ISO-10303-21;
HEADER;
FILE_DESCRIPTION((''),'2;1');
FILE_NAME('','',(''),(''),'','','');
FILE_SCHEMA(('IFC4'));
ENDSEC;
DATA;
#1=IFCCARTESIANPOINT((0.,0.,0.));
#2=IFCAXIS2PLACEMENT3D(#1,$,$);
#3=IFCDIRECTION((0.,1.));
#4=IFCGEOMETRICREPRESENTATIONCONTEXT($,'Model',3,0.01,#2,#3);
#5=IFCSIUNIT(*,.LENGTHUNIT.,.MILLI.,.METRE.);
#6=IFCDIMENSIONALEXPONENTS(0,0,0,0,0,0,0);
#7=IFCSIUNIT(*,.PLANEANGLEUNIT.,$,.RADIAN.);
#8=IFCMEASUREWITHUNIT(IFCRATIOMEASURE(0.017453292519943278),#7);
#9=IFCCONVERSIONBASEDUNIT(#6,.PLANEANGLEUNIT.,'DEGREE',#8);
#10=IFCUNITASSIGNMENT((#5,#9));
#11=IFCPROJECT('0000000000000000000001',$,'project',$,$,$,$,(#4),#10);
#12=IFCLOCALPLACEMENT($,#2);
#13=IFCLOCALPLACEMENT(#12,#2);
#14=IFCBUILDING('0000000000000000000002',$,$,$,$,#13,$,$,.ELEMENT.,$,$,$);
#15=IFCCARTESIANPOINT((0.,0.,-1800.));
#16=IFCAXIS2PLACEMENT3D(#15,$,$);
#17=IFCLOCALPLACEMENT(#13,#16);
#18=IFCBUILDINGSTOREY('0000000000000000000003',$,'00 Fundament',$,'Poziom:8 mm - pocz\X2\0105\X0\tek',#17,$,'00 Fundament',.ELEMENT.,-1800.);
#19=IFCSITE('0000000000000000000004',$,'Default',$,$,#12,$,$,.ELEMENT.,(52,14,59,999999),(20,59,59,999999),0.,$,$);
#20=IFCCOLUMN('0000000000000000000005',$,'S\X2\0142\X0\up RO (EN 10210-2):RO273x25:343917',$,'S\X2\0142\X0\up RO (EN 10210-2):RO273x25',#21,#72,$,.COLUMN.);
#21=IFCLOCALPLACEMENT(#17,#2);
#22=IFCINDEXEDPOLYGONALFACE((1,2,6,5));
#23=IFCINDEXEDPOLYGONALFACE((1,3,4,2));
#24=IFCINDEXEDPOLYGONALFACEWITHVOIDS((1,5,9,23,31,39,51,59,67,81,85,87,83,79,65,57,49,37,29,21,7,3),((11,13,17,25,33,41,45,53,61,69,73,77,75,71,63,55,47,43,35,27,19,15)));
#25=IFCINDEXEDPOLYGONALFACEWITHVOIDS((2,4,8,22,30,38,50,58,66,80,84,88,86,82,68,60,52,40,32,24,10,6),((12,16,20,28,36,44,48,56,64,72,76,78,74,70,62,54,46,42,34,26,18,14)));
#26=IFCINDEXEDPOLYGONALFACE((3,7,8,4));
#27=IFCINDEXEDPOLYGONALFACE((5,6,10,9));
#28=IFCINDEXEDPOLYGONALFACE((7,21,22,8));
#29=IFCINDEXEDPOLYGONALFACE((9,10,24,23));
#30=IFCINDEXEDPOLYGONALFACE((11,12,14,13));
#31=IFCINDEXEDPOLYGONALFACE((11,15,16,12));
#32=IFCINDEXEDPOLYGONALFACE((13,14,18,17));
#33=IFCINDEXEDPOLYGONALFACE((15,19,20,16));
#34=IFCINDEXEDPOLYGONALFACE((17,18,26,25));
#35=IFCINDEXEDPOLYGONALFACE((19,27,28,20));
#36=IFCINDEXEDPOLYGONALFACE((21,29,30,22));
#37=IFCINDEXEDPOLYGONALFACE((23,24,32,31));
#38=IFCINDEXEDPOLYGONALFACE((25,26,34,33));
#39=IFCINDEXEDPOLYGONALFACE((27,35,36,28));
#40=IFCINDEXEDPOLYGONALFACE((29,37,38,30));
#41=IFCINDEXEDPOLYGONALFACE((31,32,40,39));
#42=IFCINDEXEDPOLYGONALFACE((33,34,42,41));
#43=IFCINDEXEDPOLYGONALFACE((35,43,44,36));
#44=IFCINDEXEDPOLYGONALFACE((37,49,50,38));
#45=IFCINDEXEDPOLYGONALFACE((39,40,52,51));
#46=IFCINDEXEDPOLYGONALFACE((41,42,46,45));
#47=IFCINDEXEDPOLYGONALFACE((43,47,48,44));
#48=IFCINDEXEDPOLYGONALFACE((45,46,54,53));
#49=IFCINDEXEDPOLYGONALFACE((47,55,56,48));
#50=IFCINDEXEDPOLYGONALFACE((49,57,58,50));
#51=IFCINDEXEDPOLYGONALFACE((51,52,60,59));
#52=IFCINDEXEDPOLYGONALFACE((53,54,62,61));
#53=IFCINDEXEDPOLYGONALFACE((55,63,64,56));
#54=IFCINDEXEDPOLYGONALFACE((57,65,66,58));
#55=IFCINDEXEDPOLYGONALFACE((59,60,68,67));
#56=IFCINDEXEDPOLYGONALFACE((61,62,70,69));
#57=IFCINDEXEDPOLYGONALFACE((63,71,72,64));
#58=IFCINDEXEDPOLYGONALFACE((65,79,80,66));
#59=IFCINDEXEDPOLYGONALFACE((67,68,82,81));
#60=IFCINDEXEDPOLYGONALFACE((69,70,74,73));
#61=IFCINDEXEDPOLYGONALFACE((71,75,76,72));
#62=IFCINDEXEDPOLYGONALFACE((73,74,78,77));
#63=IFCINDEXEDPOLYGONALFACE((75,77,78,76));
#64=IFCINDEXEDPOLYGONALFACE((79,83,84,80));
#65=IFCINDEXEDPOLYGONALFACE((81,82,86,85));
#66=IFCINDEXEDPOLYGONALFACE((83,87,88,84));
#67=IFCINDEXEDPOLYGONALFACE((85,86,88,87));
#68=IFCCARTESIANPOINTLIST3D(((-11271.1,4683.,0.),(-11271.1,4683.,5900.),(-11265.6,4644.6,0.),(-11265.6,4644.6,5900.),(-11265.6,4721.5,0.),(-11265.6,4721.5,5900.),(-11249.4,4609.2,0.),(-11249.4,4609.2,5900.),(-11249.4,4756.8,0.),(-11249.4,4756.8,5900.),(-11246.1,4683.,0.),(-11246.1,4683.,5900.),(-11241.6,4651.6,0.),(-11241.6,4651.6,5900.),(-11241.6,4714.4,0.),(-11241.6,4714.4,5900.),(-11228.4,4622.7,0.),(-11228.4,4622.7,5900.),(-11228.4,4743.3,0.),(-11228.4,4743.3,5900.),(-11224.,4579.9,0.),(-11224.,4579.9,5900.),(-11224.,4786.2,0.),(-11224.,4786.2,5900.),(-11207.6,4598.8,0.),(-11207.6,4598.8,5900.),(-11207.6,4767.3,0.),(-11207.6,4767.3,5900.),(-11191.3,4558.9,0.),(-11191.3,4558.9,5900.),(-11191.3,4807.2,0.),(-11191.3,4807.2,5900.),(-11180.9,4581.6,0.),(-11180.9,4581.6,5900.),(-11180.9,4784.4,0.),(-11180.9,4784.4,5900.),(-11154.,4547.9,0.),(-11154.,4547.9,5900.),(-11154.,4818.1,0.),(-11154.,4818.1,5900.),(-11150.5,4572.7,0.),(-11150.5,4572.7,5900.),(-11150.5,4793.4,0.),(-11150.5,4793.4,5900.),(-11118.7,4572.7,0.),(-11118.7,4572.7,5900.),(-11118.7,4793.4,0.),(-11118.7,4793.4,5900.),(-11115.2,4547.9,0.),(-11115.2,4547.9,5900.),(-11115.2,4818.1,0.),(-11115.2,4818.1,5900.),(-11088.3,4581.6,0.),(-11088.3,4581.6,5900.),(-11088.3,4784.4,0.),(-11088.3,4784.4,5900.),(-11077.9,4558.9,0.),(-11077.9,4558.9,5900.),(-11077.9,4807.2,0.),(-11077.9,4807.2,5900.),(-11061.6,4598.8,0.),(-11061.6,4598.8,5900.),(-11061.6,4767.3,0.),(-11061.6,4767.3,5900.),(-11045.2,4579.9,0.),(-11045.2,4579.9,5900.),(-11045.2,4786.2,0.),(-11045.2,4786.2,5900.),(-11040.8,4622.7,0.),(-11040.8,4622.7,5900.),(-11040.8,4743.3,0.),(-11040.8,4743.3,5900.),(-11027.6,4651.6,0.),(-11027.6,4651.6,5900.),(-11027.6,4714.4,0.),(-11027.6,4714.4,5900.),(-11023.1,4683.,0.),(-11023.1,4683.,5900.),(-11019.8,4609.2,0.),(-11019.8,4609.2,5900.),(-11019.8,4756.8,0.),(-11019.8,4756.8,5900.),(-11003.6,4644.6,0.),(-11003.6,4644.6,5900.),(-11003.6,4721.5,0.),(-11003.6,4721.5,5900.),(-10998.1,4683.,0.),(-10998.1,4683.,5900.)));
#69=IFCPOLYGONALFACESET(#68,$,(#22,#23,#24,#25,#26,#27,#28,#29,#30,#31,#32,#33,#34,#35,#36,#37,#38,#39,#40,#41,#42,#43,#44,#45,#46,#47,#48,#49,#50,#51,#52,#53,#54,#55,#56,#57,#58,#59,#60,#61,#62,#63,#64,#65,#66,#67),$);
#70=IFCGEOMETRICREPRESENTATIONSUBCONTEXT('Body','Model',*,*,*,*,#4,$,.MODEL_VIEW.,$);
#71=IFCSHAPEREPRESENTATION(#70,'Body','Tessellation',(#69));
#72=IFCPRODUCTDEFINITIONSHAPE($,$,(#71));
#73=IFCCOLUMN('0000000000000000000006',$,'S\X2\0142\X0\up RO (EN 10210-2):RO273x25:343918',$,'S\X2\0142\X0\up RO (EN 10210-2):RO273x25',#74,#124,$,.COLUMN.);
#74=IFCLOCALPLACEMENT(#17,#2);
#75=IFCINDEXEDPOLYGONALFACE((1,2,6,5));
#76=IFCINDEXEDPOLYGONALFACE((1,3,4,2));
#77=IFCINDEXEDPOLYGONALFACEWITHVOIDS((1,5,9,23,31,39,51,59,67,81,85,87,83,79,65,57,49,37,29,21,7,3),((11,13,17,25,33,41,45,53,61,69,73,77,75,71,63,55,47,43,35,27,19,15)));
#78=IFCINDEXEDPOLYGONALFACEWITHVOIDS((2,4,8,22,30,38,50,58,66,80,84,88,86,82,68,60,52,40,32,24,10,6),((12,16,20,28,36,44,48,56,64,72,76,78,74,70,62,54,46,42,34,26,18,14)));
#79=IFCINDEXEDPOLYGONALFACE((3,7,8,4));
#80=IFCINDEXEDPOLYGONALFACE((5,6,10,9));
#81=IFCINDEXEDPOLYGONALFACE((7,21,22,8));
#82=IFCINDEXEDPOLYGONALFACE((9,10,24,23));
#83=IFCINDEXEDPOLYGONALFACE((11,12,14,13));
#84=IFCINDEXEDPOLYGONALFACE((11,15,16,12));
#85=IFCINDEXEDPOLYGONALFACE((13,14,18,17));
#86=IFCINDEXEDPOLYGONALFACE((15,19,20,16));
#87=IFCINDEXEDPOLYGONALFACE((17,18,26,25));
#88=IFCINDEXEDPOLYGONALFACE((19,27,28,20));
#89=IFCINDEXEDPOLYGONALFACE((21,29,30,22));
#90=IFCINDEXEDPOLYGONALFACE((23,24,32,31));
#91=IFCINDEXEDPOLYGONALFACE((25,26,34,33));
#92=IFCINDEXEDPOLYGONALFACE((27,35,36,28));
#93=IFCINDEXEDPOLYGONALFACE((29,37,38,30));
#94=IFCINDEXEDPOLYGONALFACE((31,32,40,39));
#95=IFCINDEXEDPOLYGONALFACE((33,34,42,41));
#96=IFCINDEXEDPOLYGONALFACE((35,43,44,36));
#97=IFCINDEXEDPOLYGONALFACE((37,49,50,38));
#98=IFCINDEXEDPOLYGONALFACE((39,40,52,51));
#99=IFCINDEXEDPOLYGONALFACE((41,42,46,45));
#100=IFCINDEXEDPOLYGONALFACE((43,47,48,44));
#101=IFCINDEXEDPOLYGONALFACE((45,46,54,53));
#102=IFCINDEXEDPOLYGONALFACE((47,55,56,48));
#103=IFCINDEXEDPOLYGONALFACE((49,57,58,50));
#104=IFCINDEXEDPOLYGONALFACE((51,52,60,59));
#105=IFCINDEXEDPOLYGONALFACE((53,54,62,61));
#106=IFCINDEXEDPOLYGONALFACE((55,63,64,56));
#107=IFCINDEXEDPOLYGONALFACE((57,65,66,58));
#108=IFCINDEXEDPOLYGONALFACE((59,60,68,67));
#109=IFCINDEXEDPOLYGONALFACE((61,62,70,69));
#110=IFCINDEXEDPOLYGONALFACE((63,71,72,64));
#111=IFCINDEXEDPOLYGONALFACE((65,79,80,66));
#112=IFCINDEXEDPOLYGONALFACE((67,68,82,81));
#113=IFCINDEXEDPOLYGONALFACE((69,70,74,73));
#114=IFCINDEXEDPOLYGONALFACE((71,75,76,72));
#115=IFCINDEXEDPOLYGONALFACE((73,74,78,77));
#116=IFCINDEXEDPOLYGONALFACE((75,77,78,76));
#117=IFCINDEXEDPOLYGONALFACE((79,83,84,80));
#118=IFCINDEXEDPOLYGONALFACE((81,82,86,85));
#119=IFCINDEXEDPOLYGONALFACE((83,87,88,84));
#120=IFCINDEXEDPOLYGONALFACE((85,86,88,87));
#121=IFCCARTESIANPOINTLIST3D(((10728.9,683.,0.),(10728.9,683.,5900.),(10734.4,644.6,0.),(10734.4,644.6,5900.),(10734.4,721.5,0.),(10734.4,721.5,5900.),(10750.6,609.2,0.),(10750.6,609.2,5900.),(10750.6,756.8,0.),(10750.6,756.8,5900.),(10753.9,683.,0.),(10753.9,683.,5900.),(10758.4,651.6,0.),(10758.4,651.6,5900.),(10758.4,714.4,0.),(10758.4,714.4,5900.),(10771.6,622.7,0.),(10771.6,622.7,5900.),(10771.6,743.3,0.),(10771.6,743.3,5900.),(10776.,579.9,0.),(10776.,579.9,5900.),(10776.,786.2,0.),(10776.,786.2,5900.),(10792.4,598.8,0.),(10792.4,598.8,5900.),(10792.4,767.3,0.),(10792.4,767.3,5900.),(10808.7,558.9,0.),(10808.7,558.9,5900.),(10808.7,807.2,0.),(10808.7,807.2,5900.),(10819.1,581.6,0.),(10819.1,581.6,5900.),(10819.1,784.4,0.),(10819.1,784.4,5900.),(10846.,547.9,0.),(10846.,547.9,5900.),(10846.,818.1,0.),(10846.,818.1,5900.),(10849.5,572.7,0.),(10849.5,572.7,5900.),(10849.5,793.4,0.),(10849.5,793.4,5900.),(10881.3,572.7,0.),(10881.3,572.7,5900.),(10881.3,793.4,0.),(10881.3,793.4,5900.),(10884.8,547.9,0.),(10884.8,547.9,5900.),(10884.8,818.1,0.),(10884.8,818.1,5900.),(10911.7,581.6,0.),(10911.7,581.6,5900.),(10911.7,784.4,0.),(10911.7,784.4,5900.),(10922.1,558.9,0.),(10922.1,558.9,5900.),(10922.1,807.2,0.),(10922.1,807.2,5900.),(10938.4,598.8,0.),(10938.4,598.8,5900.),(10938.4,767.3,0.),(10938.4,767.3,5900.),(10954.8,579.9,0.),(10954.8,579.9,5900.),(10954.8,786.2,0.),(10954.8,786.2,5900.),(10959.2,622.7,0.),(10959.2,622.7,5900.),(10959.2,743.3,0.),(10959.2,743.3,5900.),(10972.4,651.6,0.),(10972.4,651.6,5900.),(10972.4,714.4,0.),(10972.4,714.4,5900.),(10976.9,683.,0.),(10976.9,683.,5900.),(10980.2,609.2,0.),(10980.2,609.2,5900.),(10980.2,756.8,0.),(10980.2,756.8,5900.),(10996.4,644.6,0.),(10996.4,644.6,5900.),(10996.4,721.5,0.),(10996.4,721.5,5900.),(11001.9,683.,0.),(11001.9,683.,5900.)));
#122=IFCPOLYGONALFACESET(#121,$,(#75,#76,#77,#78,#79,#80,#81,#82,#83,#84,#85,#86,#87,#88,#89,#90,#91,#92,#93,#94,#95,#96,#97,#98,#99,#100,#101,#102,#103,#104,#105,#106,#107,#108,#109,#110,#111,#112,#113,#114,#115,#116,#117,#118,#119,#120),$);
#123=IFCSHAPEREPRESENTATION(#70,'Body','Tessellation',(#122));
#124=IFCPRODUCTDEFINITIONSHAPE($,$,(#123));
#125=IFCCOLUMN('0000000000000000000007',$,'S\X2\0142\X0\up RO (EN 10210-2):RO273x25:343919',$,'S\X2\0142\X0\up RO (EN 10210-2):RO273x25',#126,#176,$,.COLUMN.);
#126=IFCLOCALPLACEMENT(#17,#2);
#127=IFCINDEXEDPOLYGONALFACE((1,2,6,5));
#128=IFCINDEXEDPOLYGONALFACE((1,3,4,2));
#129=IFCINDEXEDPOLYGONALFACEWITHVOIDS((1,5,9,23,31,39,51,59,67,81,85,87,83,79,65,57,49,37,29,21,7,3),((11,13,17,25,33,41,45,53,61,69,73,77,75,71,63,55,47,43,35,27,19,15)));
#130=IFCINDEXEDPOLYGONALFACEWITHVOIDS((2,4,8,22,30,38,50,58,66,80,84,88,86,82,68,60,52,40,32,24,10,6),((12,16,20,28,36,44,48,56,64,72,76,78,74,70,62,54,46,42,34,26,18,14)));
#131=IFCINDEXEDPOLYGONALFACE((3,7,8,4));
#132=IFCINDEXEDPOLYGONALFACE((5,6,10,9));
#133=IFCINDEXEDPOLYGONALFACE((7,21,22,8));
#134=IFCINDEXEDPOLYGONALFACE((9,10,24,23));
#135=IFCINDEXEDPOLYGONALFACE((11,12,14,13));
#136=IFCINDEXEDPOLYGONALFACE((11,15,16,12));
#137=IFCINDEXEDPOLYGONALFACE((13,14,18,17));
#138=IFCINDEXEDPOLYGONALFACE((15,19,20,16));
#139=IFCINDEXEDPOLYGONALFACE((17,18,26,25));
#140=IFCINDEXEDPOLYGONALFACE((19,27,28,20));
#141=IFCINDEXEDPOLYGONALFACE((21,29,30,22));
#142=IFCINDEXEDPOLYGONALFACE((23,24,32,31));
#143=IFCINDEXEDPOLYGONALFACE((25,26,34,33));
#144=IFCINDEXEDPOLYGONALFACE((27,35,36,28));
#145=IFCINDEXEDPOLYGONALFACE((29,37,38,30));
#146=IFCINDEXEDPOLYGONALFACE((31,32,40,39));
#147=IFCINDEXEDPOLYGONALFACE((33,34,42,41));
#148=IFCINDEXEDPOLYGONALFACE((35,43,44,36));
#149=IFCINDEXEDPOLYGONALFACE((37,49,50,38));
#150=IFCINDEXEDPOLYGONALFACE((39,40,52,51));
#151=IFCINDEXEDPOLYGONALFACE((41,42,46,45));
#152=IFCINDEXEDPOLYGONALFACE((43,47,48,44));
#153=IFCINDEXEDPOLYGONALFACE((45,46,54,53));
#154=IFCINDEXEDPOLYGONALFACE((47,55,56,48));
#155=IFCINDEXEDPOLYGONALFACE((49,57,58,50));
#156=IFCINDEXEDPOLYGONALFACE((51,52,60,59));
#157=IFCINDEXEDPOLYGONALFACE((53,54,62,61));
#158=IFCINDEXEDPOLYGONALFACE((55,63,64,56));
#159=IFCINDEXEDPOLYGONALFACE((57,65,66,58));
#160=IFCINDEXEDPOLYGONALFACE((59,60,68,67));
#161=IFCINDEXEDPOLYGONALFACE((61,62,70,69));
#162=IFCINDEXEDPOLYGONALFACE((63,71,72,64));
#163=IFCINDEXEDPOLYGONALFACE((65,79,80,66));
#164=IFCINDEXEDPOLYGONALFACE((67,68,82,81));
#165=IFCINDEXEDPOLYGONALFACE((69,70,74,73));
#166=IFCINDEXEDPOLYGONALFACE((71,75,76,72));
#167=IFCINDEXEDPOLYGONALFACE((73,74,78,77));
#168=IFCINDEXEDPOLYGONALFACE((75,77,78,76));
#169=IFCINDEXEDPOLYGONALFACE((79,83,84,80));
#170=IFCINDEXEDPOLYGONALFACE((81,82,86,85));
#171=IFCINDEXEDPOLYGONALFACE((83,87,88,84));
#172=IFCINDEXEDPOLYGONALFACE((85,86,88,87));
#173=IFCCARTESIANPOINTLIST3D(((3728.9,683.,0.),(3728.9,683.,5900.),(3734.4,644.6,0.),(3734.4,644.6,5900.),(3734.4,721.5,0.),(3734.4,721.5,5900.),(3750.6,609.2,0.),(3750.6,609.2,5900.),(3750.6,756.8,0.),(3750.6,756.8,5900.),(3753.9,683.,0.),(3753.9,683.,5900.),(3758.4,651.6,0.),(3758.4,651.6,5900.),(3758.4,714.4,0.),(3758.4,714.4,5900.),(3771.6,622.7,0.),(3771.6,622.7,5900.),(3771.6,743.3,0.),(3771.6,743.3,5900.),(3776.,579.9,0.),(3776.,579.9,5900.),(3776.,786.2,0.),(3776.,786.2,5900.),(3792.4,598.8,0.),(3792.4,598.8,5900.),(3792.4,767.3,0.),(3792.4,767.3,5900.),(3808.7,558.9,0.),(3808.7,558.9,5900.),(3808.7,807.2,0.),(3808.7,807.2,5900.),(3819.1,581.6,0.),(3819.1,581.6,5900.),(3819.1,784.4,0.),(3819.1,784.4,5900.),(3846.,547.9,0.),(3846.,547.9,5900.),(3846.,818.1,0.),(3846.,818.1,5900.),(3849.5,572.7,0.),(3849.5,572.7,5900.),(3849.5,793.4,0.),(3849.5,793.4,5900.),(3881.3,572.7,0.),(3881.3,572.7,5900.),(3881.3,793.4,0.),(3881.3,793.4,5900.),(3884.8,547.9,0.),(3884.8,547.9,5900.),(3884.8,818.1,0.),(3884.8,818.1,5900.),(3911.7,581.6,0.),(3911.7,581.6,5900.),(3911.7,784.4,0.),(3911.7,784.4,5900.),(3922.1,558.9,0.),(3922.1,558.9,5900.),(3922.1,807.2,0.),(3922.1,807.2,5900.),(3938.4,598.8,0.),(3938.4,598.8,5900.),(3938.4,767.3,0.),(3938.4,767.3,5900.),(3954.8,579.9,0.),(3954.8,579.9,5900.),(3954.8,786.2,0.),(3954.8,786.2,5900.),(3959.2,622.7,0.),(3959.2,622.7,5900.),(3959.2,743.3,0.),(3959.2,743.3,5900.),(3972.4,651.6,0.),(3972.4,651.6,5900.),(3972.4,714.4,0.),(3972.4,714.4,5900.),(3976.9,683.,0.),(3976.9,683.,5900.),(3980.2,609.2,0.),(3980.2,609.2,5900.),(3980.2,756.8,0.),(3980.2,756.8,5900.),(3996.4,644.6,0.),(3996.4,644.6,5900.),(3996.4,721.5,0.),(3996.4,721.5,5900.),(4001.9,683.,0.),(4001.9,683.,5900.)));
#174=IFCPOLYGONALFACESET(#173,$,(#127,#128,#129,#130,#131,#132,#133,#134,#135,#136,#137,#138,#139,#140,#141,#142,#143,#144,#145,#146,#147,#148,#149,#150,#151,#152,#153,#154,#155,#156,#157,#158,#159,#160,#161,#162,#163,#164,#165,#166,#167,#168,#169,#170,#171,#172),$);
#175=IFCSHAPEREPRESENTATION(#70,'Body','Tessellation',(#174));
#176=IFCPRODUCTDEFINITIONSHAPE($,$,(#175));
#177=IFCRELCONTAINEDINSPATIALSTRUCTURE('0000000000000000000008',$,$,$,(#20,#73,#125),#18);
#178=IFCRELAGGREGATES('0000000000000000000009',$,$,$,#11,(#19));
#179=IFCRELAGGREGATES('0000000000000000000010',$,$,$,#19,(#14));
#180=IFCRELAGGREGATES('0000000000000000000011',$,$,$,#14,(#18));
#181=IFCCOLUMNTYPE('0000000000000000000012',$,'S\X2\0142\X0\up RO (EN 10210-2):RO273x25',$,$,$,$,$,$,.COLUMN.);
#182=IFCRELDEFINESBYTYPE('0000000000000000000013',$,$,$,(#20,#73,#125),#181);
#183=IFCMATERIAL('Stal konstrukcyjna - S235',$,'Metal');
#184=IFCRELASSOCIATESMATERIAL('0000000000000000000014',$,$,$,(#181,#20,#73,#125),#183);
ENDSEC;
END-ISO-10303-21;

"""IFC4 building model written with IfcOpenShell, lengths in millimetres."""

from ifc_helpers import new_model, entity, si_unit, converted_unit, direction, frame, origin, place, context, subcontext, project, spatial, arc, indexed_curve, outline, extrude, source, transform, mapped, material, type_object, type_shapes, element, save


model = new_model("IFC4")

# Units and contexts
model_context = context("Model", 3, precision=0.01, world=origin(), true_north=direction((0.0, 1.0)))
body_context = subcontext(model_context, "Body", "Model", "MODEL_VIEW")
ifc_project = project(units=[si_unit("LENGTHUNIT", "METRE", prefix="MILLI"), converted_unit("PLANEANGLEUNIT", "DEGREE", entity("IfcRatioMeasure", 0.017453292519943278), si_unit("PLANEANGLEUNIT", "RADIAN"), dimensions=[0, 0, 0, 0, 0, 0, 0])], contexts=[model_context])

# Site, building, storey
site_placement = place(None, origin())
site = spatial("IfcSite", under=ifc_project, at=site_placement, Name="Default", CompositionType="ELEMENT", RefLatitude=(52, 14, 59, 999999), RefLongitude=(20, 59, 59, 999999), RefElevation=0.0)
building_placement = place(site_placement, origin())
building = spatial("IfcBuilding", under=site, at=building_placement, CompositionType="ELEMENT")
storey_placement = place(building_placement, frame((0.0, 0.0, -1800.0)))
storey = spatial("IfcBuildingStorey", under=building, at=storey_placement, Name="00 Fundament", ObjectType="Poziom:8 mm - początek", LongName="00 Fundament", CompositionType="ELEMENT", Elevation=-1800.0)

# Columns
ifc_material_1 = material(Name="Stal konstrukcyjna - S235", Category="Metal")
column_type = type_object("IfcColumnType", Name="Słup RO (EN 10210-2):RO273x25", PredefinedType="COLUMN", material=ifc_material_1)
shared_shape = source(origin(), body_context, "Body", "SweptSolid", [
    extrude(outline(indexed_curve([(-136.5, 0.0), (0.0, -136.5), (136.5, 0.0), (0.0, 136.5)], segments=[arc(1, 2, 3), arc(3, 4, 1)], self_intersect=False), holes=[indexed_curve([(-111.5, 0.0), (0.0, 111.5), (111.5, 0.0), (0.0, -111.5)], segments=[arc(1, 2, 3), arc(3, 4, 1)], self_intersect=False)]), frame((0.0, 0.0, -1800.0)), (0.0, 0.0, 1.0), 5900.0),
])
type_shapes(column_type, [shared_shape])
for number, where, name in (
    (1, (-11134.6, 4683.0, 1800.0), "Słup RO (EN 10210-2):RO273x25:343917"),
    (2, (10865.4, 683.0, 1800.0), "Słup RO (EN 10210-2):RO273x25:343918"),
    (3, (3865.4, 683.0, 1800.0), "Słup RO (EN 10210-2):RO273x25:343919"),
):
    element("IfcColumn", number, at=place(storey_placement, frame(where)), inside=storey, type_object=column_type, material=ifc_material_1, Name=name, ObjectType="Słup RO (EN 10210-2):RO273x25", PredefinedType="COLUMN", context=body_context, shape_type="MappedRepresentation", body=[
        mapped(shared_shape, transform((0.0, 0.0, 0.0), scale=1.0)),
    ])

save(model, "model.ifc")
